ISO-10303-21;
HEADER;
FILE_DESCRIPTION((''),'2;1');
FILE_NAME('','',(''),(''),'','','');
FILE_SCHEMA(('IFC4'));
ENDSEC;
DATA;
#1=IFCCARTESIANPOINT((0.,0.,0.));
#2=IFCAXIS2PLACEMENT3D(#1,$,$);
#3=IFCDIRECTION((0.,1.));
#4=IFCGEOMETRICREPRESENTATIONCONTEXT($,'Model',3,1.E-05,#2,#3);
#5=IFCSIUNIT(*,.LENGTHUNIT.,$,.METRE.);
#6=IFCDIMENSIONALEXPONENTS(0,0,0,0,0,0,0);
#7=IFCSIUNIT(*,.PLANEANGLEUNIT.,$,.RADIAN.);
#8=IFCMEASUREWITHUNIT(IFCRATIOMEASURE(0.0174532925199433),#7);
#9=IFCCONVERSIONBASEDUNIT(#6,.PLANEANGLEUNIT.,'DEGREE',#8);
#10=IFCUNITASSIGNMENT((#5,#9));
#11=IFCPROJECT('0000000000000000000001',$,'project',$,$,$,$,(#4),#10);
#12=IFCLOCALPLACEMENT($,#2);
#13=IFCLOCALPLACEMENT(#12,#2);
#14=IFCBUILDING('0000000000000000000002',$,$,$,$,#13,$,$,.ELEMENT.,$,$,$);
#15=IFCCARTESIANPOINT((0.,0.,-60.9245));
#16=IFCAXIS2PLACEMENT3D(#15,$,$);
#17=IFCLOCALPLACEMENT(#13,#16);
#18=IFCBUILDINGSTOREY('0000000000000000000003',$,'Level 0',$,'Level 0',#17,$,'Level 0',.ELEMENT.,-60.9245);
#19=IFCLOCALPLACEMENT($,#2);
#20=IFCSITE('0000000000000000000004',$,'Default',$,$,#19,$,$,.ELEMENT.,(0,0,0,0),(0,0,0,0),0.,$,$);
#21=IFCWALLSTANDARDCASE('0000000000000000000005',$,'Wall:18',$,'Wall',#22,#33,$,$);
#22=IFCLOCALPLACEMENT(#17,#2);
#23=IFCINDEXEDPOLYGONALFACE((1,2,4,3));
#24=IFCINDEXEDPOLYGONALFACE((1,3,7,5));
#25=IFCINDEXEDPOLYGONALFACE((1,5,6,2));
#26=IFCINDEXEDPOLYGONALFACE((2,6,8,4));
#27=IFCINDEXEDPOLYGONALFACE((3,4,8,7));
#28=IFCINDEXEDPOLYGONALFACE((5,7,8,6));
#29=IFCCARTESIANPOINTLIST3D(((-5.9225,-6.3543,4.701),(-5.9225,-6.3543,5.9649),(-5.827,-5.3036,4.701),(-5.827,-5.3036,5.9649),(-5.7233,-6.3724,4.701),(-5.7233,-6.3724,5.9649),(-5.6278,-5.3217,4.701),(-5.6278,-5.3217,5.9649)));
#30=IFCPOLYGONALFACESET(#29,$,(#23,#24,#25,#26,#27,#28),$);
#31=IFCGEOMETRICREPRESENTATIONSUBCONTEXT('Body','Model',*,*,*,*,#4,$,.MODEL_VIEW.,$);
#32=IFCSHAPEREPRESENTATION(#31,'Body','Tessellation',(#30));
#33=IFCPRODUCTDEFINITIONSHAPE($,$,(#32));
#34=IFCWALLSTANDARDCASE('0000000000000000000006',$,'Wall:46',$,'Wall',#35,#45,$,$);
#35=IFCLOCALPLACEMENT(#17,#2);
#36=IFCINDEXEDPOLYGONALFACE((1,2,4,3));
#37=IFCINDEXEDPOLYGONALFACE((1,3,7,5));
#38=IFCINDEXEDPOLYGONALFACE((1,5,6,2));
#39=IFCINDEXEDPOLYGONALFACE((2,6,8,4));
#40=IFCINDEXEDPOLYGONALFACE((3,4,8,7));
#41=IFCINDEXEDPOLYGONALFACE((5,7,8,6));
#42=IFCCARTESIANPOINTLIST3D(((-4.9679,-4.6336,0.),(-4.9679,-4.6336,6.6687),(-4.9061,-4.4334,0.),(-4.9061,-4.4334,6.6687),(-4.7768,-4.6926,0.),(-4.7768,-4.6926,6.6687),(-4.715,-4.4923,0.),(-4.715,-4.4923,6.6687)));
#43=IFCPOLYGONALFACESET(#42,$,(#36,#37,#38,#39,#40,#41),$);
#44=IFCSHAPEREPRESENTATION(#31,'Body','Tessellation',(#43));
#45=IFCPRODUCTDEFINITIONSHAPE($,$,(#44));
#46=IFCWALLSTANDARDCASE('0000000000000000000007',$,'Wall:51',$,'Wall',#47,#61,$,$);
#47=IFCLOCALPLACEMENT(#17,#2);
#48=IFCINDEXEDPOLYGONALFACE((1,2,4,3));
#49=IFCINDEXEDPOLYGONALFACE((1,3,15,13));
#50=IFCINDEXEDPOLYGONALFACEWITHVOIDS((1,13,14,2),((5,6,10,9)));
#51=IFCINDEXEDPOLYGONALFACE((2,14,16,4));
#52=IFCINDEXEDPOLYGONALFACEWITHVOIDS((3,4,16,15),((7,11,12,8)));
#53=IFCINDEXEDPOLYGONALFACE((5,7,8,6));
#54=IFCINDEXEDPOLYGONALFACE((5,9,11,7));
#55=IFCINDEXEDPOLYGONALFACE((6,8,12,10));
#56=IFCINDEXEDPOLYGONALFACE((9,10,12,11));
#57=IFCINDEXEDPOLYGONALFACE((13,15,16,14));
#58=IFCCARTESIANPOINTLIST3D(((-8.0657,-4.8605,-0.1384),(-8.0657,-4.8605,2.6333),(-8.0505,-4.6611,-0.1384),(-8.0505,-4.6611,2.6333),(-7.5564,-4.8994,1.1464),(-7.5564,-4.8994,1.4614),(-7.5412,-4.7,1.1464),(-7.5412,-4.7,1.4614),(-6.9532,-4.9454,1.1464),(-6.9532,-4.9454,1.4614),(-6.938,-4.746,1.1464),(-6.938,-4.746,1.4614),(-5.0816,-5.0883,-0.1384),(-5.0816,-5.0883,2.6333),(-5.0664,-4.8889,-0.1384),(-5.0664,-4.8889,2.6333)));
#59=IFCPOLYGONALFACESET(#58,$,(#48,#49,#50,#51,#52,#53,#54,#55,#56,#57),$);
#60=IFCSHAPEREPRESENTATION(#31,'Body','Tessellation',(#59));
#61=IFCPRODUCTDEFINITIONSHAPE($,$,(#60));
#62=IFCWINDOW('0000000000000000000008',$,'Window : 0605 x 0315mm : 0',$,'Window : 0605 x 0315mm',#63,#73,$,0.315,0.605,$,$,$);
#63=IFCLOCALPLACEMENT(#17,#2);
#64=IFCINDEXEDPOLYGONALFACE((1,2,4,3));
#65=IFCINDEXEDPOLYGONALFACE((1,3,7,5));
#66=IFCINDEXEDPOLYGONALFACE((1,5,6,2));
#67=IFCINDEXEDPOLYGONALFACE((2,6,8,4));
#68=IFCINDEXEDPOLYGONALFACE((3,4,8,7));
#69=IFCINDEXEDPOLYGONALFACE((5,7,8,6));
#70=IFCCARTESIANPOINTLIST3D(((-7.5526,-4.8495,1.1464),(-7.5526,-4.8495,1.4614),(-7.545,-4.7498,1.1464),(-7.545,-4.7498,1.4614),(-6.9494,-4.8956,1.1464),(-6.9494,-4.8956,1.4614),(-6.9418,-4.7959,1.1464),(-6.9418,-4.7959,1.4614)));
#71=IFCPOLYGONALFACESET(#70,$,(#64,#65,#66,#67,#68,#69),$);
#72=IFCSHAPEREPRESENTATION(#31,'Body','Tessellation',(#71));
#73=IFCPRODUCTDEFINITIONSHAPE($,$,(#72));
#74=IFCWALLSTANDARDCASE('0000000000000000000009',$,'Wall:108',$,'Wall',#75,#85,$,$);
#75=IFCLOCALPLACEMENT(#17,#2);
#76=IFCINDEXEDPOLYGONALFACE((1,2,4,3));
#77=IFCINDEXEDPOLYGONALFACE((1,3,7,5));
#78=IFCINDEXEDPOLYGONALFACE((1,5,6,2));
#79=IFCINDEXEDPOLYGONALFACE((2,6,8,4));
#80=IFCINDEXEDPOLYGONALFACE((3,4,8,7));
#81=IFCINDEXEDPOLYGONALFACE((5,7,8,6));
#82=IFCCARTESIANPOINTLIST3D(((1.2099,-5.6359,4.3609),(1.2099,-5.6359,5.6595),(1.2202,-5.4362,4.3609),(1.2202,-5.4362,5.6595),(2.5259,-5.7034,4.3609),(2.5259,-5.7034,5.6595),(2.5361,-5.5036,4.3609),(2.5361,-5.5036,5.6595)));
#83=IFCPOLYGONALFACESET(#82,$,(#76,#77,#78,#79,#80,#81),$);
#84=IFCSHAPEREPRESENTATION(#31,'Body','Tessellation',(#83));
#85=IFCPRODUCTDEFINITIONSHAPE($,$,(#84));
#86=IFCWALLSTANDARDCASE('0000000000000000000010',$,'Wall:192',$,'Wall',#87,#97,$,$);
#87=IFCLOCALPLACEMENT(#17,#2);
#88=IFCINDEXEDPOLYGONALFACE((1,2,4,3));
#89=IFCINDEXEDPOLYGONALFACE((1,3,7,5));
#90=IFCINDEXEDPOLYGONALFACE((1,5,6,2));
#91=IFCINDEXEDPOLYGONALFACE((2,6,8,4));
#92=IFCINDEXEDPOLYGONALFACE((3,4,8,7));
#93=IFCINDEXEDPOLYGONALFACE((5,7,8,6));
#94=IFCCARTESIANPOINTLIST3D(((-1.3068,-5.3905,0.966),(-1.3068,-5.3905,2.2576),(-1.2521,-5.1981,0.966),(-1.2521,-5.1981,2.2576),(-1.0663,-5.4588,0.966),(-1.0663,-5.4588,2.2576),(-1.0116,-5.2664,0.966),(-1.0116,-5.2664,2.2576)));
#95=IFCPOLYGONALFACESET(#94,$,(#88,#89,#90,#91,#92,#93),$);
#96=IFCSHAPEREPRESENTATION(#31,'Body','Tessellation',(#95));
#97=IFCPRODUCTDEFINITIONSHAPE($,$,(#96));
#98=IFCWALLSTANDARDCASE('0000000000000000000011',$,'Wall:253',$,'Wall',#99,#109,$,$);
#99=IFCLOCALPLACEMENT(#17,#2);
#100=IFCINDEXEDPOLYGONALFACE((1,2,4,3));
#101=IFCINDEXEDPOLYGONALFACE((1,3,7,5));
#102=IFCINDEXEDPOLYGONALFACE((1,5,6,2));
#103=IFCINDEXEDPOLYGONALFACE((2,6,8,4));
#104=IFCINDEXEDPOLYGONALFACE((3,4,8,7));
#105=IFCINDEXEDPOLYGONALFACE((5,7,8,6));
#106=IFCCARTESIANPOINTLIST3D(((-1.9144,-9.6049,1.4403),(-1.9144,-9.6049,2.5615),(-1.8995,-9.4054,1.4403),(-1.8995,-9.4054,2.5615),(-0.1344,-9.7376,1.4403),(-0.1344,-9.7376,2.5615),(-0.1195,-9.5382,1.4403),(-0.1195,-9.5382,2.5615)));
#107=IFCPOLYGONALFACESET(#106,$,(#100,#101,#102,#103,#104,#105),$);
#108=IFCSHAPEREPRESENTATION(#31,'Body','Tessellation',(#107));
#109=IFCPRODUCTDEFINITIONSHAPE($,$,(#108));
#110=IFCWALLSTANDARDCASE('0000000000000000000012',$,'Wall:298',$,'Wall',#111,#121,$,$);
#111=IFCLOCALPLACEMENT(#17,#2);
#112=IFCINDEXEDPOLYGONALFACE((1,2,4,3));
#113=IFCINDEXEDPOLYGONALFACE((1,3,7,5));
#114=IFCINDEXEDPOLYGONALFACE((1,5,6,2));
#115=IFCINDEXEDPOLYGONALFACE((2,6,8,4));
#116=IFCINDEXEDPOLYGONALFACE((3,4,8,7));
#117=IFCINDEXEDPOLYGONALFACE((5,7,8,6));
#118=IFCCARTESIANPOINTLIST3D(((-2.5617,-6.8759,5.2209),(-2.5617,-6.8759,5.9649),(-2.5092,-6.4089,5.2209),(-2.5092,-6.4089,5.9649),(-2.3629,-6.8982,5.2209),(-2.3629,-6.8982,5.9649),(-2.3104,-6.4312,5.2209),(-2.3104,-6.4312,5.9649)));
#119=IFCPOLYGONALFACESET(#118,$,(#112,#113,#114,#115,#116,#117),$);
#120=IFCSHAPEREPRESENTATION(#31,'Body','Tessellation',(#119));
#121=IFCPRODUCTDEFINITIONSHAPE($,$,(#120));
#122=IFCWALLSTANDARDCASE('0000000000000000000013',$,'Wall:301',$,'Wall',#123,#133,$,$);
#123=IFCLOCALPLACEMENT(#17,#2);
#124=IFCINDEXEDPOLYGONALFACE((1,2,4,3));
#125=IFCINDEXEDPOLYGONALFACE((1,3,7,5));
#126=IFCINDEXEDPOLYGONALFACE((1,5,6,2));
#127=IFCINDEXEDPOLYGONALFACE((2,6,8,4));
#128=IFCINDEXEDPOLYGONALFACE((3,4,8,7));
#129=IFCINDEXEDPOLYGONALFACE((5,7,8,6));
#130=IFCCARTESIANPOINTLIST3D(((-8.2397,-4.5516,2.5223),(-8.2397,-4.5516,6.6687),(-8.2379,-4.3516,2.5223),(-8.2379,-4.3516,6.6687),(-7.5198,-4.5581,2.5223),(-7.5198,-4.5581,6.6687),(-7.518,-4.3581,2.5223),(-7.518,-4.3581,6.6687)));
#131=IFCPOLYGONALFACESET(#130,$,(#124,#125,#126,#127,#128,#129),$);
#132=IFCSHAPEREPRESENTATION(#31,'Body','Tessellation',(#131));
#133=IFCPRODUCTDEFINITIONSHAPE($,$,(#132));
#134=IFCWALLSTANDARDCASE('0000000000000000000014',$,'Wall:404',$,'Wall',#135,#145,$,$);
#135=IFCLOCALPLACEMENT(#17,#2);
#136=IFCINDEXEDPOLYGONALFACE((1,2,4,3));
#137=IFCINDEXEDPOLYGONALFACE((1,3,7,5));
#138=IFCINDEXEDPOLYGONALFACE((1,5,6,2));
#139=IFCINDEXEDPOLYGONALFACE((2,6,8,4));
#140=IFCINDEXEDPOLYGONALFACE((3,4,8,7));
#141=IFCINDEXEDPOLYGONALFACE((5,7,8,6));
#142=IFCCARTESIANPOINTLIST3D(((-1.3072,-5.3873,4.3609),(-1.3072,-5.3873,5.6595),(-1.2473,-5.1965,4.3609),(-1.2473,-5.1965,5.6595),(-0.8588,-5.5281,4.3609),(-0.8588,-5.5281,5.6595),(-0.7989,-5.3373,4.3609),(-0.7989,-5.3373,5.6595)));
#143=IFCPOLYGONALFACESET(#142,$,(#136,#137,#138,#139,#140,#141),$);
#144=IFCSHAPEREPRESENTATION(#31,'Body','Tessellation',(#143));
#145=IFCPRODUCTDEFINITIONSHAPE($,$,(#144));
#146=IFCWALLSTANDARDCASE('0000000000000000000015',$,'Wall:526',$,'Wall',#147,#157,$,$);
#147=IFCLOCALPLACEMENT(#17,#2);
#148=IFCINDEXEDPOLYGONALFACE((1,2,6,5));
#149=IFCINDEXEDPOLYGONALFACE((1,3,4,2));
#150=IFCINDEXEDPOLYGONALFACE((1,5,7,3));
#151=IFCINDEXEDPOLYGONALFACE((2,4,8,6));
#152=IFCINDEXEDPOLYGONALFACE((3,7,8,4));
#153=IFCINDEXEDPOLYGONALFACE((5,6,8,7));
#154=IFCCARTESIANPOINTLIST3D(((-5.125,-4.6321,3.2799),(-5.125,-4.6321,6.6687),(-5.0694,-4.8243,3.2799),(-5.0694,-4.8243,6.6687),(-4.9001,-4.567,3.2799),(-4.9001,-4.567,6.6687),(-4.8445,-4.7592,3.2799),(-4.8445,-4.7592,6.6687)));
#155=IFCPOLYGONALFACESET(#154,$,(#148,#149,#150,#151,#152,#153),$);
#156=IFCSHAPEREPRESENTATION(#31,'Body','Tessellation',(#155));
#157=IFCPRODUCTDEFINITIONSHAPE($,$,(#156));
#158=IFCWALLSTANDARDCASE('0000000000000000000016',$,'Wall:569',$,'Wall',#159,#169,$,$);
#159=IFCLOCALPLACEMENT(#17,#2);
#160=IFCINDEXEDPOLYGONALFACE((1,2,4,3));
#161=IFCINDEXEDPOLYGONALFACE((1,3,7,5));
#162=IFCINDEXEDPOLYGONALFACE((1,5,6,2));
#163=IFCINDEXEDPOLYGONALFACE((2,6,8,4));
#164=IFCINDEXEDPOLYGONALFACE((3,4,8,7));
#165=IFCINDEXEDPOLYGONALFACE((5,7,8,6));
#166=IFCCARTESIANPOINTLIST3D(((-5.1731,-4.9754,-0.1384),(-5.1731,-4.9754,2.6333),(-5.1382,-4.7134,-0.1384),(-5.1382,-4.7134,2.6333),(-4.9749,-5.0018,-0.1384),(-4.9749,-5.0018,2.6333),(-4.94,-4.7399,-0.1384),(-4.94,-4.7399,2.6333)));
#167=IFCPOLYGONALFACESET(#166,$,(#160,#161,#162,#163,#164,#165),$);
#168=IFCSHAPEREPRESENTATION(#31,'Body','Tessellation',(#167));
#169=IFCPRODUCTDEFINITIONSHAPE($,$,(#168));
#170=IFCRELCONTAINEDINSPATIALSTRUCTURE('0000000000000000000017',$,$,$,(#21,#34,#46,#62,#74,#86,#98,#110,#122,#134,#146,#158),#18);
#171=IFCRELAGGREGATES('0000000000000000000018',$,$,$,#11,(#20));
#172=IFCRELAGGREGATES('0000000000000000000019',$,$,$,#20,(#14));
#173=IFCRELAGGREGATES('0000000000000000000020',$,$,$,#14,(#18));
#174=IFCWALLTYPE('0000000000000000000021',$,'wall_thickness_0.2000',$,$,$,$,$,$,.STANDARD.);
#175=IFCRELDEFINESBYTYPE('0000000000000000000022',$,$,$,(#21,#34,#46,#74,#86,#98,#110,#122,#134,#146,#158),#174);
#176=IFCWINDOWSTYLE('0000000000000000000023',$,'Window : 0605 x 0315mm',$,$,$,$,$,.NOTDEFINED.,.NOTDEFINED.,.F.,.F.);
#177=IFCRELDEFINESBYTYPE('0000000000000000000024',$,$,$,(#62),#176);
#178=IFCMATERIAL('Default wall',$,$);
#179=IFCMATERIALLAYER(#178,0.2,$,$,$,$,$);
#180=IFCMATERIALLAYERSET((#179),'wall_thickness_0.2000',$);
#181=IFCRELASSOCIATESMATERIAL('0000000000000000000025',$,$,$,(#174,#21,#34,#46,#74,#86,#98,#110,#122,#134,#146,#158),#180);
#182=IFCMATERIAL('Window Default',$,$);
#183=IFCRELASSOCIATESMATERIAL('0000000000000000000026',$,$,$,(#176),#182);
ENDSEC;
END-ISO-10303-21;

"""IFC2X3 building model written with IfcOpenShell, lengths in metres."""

from ifc_helpers import new_model, entity, si_unit, converted_unit, direction, frame, frame_2d, origin, origin_2d_with_axis, place, context, subcontext, project, spatial, polyline, rectangle, outline, extrude, source, transform, mapped, material, layer, layer_set, layer_usage, type_object, type_shapes, element, fill, save


model = new_model("IFC2X3")

# Units and contexts
model_context = context("Model", 3, precision=1e-05, world=origin(), true_north=direction((0.0, 1.0)))
body_context = subcontext(model_context, "Body", "Model", "MODEL_VIEW")
ifc_project = project(units=[si_unit("LENGTHUNIT", "METRE"), converted_unit("PLANEANGLEUNIT", "DEGREE", entity("IfcRatioMeasure", 0.0174532925199433), si_unit("PLANEANGLEUNIT", "RADIAN"), dimensions=[0, 0, 0, 0, 0, 0, 0])], contexts=[model_context])

# Site, building, storey
site_placement = place(None, origin())
site = spatial("IfcSite", under=ifc_project, at=site_placement, Name="Default", CompositionType="ELEMENT", RefLatitude=(0, 0, 0, 0), RefLongitude=(0, 0, 0, 0), RefElevation=0.0)
placement_1 = place(None, origin())
building_placement = place(placement_1, origin())
building = spatial("IfcBuilding", under=site, at=building_placement, CompositionType="ELEMENT")
storey_placement = place(building_placement, frame((0.0, 0.0, -60.9245)))
storey = spatial("IfcBuildingStorey", under=building, at=storey_placement, Name="Level 0", ObjectType="Level 0", LongName="Level 0", CompositionType="ELEMENT", Elevation=-60.9245)

# Walls
ifc_material_1 = material(Name="Default wall")
ifc_layer = layer(ifc_material_1, 0.2)
ifc_layer_set = layer_set([ifc_layer], Name="wall_thickness_0.2000")
ifc_layer_usage = layer_usage(ifc_layer_set, "AXIS2", "POSITIVE", -0.1)
wall_type = type_object("IfcWallType", Name="wall_thickness_0.2000", PredefinedType="STANDARD", material=ifc_layer_set)
placement_2 = place(building_placement, frame((0.0, 0.0, -56.2235)))
wall_1_placement = place(placement_2, frame((-5.7274, -5.3127, 0.0), z_axis=(0.0, 0.0, 1.0), x_axis=(-0.090533, -0.995893, 0.0)))
element("IfcWallStandardCase", 1, at=wall_1_placement, inside=storey, type_object=wall_type, material=ifc_layer_usage, Name="Wall:18", ObjectType="Wall", context=body_context, shape_type="SweptSolid", body=[
    extrude(outline(polyline([(1.055, -0.1), (1.055, 0.1), (0.0, 0.1), (0.0, -0.1), (1.055, -0.1)])), origin(), (0.0, 0.0, 1.0), 1.2639),
])
wall_2_placement = place(storey_placement, frame((-4.8723, -4.6631, 0.0), z_axis=(0.0, 0.0, 1.0), x_axis=(0.294679, 0.955596, 0.0)))
element("IfcWallStandardCase", 2, at=wall_2_placement, inside=storey, type_object=wall_type, material=ifc_layer_usage, Name="Wall:46", ObjectType="Wall", context=body_context, shape_type="SweptSolid", body=[
    extrude(outline(polyline([(0.2095, -0.1), (0.2095, 0.1), (0.0, 0.1), (0.0, -0.1), (0.2095, -0.1)])), origin(), (0.0, 0.0, 1.0), 6.6687),
])

# Wall, opening, window
placement_3 = place(building_placement, frame((0.0, 0.0, -61.0629)))
wall_3_placement = place(placement_3, frame((-5.074, -4.9886, 0.0), z_axis=(0.0, 0.0, 1.0), x_axis=(-0.997099, 0.07611, 0.0)))
wall_3 = element("IfcWallStandardCase", 3, at=wall_3_placement, inside=storey, type_object=wall_type, material=ifc_layer_usage, Name="Wall:51", ObjectType="Wall", context=body_context, shape_type="SweptSolid", body=[
    extrude(outline(polyline([(2.9928, -0.1), (2.9928, 0.1), (0.0, 0.1), (0.0, -0.1), (2.9928, -0.1)])), origin(), (0.0, 0.0, 1.0), 2.7716),
])
opening_placement = place(wall_3_placement, frame((1.877, -0.1, 1.2848)))
opening = element("IfcOpeningElement", 4, at=opening_placement, cuts=wall_3, ObjectType="Opening", context=body_context, shape_type="SweptSolid", body=[
    extrude(rectangle(XDim=0.605, YDim=0.315, at=frame_2d((0.1575, 0.3025), x_axis=(0.0, 1.0))), frame((0.0, 0.0, 0.0), z_axis=(0.0, 1.0, 0.0), x_axis=(0.0, 0.0, 1.0)), (0.0, 0.0, 1.0), 0.2),
])
ifc_material_2 = material(Name="Window Default")
window_style = type_object("IfcWindowStyle", Name="Window : 0605 x 0315mm", ConstructionType="NOTDEFINED", OperationType="NOTDEFINED", ParameterTakesPrecedence=False, Sizeable=False, material=ifc_material_2)
shared_shape = source(origin(), body_context, "Body", "SweptSolid", [
    extrude(rectangle(XDim=0.1, YDim=0.605, at=origin_2d_with_axis()), frame((0.3025, 0.1, 0.0), z_axis=(0.0, 0.0, 1.0), x_axis=(0.0, 1.0, 0.0)), (0.0, 0.0, 1.0), 0.315),
])
type_shapes(window_style, [shared_shape])
window_placement = place(opening_placement, origin())
window = element("IfcWindow", 5, at=window_placement, inside=storey, type_object=window_style, Name="Window : 0605 x 0315mm : 0", ObjectType="Window : 0605 x 0315mm", OverallHeight=0.315, OverallWidth=0.605, context=body_context, shape_type="MappedRepresentation", body=[
    mapped(shared_shape, transform((0.0, 0.0, 0.0), scale=1.0)),
])
fill(opening, window)

# Walls
placement_4 = place(building_placement, frame((0.0, 0.0, -56.5636)))
wall_4_placement = place(placement_4, frame((2.531, -5.6035, 0.0), z_axis=(0.0, 0.0, 1.0), x_axis=(-0.99869, 0.051176, 0.0)))
element("IfcWallStandardCase", 6, at=wall_4_placement, inside=storey, type_object=wall_type, material=ifc_layer_usage, Name="Wall:108", ObjectType="Wall", context=body_context, shape_type="SweptSolid", body=[
    extrude(outline(polyline([(1.3177, -0.1), (1.3177, 0.1), (0.0, 0.1), (0.0, -0.1), (1.3177, -0.1)])), origin(), (0.0, 0.0, 1.0), 1.2985),
])
placement_5 = place(building_placement, frame((0.0, 0.0, -59.9585)))
wall_5_placement = place(placement_5, frame((-1.0389, -5.3626, 0.0), z_axis=(0.0, 0.0, 1.0), x_axis=(-0.961932, 0.27329, 0.0)))
element("IfcWallStandardCase", 7, at=wall_5_placement, inside=storey, type_object=wall_type, material=ifc_layer_usage, Name="Wall:192", ObjectType="Wall", context=body_context, shape_type="SweptSolid", body=[
    extrude(outline(polyline([(0.25, -0.1), (0.25, 0.1), (0.0, 0.1), (0.0, -0.1), (0.25, -0.1)])), origin(), (0.0, 0.0, 1.0), 1.2916),
])
placement_6 = place(building_placement, frame((0.0, 0.0, -59.4842)))
wall_6_placement = place(placement_6, frame((-1.907, -9.5052, 0.0), z_axis=(0.0, 0.0, 1.0), x_axis=(0.997232, -0.074355, 0.0)))
element("IfcWallStandardCase", 8, at=wall_6_placement, inside=storey, type_object=wall_type, material=ifc_layer_usage, Name="Wall:253", ObjectType="Wall", context=body_context, shape_type="SweptSolid", body=[
    extrude(outline(polyline([(1.785, -0.1), (1.785, 0.1), (0.0, 0.1), (0.0, -0.1), (1.785, -0.1)])), origin(), (0.0, 0.0, 1.0), 1.1212),
])
placement_7 = place(building_placement, frame((0.0, 0.0, -55.7036)))
wall_7_placement = place(placement_7, frame((-2.4098, -6.42, 0.0), z_axis=(0.0, 0.0, 1.0), x_axis=(-0.11162, -0.993751, 0.0)))
element("IfcWallStandardCase", 9, at=wall_7_placement, inside=storey, type_object=wall_type, material=ifc_layer_usage, Name="Wall:298", ObjectType="Wall", context=body_context, shape_type="SweptSolid", body=[
    extrude(outline(polyline([(0.47, -0.1), (0.47, 0.1), (0.0, 0.1), (0.0, -0.1), (0.47, -0.1)])), origin(), (0.0, 0.0, 1.0), 0.744),
])
placement_8 = place(building_placement, frame((0.0, 0.0, -58.4022)))
wall_8_placement = place(placement_8, frame((-7.5189, -4.4581, 0.0), z_axis=(0.0, 0.0, 1.0), x_axis=(-0.999959, 0.009021, 0.0)))
element("IfcWallStandardCase", 10, at=wall_8_placement, inside=storey, type_object=wall_type, material=ifc_layer_usage, Name="Wall:301", ObjectType="Wall", context=body_context, shape_type="SweptSolid", body=[
    extrude(outline(polyline([(0.72, -0.1), (0.72, 0.1), (0.0, 0.1), (0.0, -0.1), (0.72, -0.1)])), origin(), (0.0, 0.0, 1.0), 4.1464),
])
placement_9 = place(building_placement, frame((0.0, 0.0, -56.5636)))
wall_9_placement = place(placement_9, frame((-0.8288, -5.4327, 0.0), z_axis=(0.0, 0.0, 1.0), x_axis=(-0.954068, 0.299591, 0.0)))
element("IfcWallStandardCase", 11, at=wall_9_placement, inside=storey, type_object=wall_type, material=ifc_layer_usage, Name="Wall:404", ObjectType="Wall", context=body_context, shape_type="SweptSolid", body=[
    extrude(outline(polyline([(0.47, -0.1), (0.47, 0.1), (0.0, 0.1), (0.0, -0.1), (0.47, -0.1)])), origin(), (0.0, 0.0, 1.0), 1.2985),
])
placement_10 = place(building_placement, frame((0.0, 0.0, -57.6446)))
wall_10_placement = place(placement_10, frame((-4.8723, -4.6631, 0.0), z_axis=(0.0, 0.0, 1.0), x_axis=(-0.960566, -0.278053, 0.0)))
element("IfcWallStandardCase", 12, at=wall_10_placement, inside=storey, type_object=wall_type, material=ifc_layer_usage, Name="Wall:526", ObjectType="Wall", context=body_context, shape_type="SweptSolid", body=[
    extrude(outline(polyline([(0.2341, -0.1), (0.2341, 0.1), (0.0, 0.1), (0.0, -0.1), (0.2341, -0.1)])), origin(), (0.0, 0.0, 1.0), 3.3888),
])
placement_11 = place(building_placement, frame((0.0, 0.0, -61.0629)))
wall_11_placement = place(placement_11, frame((-5.0391, -4.7267, 0.0), z_axis=(0.0, 0.0, 1.0), x_axis=(-0.132092, -0.991238, 0.0)))
element("IfcWallStandardCase", 13, at=wall_11_placement, inside=storey, type_object=wall_type, material=ifc_layer_usage, Name="Wall:569", ObjectType="Wall", context=body_context, shape_type="SweptSolid", body=[
    extrude(outline(polyline([(0.2642, -0.1), (0.2642, 0.1), (0.0, 0.1), (0.0, -0.1), (0.2642, -0.1)])), origin(), (0.0, 0.0, 1.0), 2.7716),
])

save(model, "model.ifc")
